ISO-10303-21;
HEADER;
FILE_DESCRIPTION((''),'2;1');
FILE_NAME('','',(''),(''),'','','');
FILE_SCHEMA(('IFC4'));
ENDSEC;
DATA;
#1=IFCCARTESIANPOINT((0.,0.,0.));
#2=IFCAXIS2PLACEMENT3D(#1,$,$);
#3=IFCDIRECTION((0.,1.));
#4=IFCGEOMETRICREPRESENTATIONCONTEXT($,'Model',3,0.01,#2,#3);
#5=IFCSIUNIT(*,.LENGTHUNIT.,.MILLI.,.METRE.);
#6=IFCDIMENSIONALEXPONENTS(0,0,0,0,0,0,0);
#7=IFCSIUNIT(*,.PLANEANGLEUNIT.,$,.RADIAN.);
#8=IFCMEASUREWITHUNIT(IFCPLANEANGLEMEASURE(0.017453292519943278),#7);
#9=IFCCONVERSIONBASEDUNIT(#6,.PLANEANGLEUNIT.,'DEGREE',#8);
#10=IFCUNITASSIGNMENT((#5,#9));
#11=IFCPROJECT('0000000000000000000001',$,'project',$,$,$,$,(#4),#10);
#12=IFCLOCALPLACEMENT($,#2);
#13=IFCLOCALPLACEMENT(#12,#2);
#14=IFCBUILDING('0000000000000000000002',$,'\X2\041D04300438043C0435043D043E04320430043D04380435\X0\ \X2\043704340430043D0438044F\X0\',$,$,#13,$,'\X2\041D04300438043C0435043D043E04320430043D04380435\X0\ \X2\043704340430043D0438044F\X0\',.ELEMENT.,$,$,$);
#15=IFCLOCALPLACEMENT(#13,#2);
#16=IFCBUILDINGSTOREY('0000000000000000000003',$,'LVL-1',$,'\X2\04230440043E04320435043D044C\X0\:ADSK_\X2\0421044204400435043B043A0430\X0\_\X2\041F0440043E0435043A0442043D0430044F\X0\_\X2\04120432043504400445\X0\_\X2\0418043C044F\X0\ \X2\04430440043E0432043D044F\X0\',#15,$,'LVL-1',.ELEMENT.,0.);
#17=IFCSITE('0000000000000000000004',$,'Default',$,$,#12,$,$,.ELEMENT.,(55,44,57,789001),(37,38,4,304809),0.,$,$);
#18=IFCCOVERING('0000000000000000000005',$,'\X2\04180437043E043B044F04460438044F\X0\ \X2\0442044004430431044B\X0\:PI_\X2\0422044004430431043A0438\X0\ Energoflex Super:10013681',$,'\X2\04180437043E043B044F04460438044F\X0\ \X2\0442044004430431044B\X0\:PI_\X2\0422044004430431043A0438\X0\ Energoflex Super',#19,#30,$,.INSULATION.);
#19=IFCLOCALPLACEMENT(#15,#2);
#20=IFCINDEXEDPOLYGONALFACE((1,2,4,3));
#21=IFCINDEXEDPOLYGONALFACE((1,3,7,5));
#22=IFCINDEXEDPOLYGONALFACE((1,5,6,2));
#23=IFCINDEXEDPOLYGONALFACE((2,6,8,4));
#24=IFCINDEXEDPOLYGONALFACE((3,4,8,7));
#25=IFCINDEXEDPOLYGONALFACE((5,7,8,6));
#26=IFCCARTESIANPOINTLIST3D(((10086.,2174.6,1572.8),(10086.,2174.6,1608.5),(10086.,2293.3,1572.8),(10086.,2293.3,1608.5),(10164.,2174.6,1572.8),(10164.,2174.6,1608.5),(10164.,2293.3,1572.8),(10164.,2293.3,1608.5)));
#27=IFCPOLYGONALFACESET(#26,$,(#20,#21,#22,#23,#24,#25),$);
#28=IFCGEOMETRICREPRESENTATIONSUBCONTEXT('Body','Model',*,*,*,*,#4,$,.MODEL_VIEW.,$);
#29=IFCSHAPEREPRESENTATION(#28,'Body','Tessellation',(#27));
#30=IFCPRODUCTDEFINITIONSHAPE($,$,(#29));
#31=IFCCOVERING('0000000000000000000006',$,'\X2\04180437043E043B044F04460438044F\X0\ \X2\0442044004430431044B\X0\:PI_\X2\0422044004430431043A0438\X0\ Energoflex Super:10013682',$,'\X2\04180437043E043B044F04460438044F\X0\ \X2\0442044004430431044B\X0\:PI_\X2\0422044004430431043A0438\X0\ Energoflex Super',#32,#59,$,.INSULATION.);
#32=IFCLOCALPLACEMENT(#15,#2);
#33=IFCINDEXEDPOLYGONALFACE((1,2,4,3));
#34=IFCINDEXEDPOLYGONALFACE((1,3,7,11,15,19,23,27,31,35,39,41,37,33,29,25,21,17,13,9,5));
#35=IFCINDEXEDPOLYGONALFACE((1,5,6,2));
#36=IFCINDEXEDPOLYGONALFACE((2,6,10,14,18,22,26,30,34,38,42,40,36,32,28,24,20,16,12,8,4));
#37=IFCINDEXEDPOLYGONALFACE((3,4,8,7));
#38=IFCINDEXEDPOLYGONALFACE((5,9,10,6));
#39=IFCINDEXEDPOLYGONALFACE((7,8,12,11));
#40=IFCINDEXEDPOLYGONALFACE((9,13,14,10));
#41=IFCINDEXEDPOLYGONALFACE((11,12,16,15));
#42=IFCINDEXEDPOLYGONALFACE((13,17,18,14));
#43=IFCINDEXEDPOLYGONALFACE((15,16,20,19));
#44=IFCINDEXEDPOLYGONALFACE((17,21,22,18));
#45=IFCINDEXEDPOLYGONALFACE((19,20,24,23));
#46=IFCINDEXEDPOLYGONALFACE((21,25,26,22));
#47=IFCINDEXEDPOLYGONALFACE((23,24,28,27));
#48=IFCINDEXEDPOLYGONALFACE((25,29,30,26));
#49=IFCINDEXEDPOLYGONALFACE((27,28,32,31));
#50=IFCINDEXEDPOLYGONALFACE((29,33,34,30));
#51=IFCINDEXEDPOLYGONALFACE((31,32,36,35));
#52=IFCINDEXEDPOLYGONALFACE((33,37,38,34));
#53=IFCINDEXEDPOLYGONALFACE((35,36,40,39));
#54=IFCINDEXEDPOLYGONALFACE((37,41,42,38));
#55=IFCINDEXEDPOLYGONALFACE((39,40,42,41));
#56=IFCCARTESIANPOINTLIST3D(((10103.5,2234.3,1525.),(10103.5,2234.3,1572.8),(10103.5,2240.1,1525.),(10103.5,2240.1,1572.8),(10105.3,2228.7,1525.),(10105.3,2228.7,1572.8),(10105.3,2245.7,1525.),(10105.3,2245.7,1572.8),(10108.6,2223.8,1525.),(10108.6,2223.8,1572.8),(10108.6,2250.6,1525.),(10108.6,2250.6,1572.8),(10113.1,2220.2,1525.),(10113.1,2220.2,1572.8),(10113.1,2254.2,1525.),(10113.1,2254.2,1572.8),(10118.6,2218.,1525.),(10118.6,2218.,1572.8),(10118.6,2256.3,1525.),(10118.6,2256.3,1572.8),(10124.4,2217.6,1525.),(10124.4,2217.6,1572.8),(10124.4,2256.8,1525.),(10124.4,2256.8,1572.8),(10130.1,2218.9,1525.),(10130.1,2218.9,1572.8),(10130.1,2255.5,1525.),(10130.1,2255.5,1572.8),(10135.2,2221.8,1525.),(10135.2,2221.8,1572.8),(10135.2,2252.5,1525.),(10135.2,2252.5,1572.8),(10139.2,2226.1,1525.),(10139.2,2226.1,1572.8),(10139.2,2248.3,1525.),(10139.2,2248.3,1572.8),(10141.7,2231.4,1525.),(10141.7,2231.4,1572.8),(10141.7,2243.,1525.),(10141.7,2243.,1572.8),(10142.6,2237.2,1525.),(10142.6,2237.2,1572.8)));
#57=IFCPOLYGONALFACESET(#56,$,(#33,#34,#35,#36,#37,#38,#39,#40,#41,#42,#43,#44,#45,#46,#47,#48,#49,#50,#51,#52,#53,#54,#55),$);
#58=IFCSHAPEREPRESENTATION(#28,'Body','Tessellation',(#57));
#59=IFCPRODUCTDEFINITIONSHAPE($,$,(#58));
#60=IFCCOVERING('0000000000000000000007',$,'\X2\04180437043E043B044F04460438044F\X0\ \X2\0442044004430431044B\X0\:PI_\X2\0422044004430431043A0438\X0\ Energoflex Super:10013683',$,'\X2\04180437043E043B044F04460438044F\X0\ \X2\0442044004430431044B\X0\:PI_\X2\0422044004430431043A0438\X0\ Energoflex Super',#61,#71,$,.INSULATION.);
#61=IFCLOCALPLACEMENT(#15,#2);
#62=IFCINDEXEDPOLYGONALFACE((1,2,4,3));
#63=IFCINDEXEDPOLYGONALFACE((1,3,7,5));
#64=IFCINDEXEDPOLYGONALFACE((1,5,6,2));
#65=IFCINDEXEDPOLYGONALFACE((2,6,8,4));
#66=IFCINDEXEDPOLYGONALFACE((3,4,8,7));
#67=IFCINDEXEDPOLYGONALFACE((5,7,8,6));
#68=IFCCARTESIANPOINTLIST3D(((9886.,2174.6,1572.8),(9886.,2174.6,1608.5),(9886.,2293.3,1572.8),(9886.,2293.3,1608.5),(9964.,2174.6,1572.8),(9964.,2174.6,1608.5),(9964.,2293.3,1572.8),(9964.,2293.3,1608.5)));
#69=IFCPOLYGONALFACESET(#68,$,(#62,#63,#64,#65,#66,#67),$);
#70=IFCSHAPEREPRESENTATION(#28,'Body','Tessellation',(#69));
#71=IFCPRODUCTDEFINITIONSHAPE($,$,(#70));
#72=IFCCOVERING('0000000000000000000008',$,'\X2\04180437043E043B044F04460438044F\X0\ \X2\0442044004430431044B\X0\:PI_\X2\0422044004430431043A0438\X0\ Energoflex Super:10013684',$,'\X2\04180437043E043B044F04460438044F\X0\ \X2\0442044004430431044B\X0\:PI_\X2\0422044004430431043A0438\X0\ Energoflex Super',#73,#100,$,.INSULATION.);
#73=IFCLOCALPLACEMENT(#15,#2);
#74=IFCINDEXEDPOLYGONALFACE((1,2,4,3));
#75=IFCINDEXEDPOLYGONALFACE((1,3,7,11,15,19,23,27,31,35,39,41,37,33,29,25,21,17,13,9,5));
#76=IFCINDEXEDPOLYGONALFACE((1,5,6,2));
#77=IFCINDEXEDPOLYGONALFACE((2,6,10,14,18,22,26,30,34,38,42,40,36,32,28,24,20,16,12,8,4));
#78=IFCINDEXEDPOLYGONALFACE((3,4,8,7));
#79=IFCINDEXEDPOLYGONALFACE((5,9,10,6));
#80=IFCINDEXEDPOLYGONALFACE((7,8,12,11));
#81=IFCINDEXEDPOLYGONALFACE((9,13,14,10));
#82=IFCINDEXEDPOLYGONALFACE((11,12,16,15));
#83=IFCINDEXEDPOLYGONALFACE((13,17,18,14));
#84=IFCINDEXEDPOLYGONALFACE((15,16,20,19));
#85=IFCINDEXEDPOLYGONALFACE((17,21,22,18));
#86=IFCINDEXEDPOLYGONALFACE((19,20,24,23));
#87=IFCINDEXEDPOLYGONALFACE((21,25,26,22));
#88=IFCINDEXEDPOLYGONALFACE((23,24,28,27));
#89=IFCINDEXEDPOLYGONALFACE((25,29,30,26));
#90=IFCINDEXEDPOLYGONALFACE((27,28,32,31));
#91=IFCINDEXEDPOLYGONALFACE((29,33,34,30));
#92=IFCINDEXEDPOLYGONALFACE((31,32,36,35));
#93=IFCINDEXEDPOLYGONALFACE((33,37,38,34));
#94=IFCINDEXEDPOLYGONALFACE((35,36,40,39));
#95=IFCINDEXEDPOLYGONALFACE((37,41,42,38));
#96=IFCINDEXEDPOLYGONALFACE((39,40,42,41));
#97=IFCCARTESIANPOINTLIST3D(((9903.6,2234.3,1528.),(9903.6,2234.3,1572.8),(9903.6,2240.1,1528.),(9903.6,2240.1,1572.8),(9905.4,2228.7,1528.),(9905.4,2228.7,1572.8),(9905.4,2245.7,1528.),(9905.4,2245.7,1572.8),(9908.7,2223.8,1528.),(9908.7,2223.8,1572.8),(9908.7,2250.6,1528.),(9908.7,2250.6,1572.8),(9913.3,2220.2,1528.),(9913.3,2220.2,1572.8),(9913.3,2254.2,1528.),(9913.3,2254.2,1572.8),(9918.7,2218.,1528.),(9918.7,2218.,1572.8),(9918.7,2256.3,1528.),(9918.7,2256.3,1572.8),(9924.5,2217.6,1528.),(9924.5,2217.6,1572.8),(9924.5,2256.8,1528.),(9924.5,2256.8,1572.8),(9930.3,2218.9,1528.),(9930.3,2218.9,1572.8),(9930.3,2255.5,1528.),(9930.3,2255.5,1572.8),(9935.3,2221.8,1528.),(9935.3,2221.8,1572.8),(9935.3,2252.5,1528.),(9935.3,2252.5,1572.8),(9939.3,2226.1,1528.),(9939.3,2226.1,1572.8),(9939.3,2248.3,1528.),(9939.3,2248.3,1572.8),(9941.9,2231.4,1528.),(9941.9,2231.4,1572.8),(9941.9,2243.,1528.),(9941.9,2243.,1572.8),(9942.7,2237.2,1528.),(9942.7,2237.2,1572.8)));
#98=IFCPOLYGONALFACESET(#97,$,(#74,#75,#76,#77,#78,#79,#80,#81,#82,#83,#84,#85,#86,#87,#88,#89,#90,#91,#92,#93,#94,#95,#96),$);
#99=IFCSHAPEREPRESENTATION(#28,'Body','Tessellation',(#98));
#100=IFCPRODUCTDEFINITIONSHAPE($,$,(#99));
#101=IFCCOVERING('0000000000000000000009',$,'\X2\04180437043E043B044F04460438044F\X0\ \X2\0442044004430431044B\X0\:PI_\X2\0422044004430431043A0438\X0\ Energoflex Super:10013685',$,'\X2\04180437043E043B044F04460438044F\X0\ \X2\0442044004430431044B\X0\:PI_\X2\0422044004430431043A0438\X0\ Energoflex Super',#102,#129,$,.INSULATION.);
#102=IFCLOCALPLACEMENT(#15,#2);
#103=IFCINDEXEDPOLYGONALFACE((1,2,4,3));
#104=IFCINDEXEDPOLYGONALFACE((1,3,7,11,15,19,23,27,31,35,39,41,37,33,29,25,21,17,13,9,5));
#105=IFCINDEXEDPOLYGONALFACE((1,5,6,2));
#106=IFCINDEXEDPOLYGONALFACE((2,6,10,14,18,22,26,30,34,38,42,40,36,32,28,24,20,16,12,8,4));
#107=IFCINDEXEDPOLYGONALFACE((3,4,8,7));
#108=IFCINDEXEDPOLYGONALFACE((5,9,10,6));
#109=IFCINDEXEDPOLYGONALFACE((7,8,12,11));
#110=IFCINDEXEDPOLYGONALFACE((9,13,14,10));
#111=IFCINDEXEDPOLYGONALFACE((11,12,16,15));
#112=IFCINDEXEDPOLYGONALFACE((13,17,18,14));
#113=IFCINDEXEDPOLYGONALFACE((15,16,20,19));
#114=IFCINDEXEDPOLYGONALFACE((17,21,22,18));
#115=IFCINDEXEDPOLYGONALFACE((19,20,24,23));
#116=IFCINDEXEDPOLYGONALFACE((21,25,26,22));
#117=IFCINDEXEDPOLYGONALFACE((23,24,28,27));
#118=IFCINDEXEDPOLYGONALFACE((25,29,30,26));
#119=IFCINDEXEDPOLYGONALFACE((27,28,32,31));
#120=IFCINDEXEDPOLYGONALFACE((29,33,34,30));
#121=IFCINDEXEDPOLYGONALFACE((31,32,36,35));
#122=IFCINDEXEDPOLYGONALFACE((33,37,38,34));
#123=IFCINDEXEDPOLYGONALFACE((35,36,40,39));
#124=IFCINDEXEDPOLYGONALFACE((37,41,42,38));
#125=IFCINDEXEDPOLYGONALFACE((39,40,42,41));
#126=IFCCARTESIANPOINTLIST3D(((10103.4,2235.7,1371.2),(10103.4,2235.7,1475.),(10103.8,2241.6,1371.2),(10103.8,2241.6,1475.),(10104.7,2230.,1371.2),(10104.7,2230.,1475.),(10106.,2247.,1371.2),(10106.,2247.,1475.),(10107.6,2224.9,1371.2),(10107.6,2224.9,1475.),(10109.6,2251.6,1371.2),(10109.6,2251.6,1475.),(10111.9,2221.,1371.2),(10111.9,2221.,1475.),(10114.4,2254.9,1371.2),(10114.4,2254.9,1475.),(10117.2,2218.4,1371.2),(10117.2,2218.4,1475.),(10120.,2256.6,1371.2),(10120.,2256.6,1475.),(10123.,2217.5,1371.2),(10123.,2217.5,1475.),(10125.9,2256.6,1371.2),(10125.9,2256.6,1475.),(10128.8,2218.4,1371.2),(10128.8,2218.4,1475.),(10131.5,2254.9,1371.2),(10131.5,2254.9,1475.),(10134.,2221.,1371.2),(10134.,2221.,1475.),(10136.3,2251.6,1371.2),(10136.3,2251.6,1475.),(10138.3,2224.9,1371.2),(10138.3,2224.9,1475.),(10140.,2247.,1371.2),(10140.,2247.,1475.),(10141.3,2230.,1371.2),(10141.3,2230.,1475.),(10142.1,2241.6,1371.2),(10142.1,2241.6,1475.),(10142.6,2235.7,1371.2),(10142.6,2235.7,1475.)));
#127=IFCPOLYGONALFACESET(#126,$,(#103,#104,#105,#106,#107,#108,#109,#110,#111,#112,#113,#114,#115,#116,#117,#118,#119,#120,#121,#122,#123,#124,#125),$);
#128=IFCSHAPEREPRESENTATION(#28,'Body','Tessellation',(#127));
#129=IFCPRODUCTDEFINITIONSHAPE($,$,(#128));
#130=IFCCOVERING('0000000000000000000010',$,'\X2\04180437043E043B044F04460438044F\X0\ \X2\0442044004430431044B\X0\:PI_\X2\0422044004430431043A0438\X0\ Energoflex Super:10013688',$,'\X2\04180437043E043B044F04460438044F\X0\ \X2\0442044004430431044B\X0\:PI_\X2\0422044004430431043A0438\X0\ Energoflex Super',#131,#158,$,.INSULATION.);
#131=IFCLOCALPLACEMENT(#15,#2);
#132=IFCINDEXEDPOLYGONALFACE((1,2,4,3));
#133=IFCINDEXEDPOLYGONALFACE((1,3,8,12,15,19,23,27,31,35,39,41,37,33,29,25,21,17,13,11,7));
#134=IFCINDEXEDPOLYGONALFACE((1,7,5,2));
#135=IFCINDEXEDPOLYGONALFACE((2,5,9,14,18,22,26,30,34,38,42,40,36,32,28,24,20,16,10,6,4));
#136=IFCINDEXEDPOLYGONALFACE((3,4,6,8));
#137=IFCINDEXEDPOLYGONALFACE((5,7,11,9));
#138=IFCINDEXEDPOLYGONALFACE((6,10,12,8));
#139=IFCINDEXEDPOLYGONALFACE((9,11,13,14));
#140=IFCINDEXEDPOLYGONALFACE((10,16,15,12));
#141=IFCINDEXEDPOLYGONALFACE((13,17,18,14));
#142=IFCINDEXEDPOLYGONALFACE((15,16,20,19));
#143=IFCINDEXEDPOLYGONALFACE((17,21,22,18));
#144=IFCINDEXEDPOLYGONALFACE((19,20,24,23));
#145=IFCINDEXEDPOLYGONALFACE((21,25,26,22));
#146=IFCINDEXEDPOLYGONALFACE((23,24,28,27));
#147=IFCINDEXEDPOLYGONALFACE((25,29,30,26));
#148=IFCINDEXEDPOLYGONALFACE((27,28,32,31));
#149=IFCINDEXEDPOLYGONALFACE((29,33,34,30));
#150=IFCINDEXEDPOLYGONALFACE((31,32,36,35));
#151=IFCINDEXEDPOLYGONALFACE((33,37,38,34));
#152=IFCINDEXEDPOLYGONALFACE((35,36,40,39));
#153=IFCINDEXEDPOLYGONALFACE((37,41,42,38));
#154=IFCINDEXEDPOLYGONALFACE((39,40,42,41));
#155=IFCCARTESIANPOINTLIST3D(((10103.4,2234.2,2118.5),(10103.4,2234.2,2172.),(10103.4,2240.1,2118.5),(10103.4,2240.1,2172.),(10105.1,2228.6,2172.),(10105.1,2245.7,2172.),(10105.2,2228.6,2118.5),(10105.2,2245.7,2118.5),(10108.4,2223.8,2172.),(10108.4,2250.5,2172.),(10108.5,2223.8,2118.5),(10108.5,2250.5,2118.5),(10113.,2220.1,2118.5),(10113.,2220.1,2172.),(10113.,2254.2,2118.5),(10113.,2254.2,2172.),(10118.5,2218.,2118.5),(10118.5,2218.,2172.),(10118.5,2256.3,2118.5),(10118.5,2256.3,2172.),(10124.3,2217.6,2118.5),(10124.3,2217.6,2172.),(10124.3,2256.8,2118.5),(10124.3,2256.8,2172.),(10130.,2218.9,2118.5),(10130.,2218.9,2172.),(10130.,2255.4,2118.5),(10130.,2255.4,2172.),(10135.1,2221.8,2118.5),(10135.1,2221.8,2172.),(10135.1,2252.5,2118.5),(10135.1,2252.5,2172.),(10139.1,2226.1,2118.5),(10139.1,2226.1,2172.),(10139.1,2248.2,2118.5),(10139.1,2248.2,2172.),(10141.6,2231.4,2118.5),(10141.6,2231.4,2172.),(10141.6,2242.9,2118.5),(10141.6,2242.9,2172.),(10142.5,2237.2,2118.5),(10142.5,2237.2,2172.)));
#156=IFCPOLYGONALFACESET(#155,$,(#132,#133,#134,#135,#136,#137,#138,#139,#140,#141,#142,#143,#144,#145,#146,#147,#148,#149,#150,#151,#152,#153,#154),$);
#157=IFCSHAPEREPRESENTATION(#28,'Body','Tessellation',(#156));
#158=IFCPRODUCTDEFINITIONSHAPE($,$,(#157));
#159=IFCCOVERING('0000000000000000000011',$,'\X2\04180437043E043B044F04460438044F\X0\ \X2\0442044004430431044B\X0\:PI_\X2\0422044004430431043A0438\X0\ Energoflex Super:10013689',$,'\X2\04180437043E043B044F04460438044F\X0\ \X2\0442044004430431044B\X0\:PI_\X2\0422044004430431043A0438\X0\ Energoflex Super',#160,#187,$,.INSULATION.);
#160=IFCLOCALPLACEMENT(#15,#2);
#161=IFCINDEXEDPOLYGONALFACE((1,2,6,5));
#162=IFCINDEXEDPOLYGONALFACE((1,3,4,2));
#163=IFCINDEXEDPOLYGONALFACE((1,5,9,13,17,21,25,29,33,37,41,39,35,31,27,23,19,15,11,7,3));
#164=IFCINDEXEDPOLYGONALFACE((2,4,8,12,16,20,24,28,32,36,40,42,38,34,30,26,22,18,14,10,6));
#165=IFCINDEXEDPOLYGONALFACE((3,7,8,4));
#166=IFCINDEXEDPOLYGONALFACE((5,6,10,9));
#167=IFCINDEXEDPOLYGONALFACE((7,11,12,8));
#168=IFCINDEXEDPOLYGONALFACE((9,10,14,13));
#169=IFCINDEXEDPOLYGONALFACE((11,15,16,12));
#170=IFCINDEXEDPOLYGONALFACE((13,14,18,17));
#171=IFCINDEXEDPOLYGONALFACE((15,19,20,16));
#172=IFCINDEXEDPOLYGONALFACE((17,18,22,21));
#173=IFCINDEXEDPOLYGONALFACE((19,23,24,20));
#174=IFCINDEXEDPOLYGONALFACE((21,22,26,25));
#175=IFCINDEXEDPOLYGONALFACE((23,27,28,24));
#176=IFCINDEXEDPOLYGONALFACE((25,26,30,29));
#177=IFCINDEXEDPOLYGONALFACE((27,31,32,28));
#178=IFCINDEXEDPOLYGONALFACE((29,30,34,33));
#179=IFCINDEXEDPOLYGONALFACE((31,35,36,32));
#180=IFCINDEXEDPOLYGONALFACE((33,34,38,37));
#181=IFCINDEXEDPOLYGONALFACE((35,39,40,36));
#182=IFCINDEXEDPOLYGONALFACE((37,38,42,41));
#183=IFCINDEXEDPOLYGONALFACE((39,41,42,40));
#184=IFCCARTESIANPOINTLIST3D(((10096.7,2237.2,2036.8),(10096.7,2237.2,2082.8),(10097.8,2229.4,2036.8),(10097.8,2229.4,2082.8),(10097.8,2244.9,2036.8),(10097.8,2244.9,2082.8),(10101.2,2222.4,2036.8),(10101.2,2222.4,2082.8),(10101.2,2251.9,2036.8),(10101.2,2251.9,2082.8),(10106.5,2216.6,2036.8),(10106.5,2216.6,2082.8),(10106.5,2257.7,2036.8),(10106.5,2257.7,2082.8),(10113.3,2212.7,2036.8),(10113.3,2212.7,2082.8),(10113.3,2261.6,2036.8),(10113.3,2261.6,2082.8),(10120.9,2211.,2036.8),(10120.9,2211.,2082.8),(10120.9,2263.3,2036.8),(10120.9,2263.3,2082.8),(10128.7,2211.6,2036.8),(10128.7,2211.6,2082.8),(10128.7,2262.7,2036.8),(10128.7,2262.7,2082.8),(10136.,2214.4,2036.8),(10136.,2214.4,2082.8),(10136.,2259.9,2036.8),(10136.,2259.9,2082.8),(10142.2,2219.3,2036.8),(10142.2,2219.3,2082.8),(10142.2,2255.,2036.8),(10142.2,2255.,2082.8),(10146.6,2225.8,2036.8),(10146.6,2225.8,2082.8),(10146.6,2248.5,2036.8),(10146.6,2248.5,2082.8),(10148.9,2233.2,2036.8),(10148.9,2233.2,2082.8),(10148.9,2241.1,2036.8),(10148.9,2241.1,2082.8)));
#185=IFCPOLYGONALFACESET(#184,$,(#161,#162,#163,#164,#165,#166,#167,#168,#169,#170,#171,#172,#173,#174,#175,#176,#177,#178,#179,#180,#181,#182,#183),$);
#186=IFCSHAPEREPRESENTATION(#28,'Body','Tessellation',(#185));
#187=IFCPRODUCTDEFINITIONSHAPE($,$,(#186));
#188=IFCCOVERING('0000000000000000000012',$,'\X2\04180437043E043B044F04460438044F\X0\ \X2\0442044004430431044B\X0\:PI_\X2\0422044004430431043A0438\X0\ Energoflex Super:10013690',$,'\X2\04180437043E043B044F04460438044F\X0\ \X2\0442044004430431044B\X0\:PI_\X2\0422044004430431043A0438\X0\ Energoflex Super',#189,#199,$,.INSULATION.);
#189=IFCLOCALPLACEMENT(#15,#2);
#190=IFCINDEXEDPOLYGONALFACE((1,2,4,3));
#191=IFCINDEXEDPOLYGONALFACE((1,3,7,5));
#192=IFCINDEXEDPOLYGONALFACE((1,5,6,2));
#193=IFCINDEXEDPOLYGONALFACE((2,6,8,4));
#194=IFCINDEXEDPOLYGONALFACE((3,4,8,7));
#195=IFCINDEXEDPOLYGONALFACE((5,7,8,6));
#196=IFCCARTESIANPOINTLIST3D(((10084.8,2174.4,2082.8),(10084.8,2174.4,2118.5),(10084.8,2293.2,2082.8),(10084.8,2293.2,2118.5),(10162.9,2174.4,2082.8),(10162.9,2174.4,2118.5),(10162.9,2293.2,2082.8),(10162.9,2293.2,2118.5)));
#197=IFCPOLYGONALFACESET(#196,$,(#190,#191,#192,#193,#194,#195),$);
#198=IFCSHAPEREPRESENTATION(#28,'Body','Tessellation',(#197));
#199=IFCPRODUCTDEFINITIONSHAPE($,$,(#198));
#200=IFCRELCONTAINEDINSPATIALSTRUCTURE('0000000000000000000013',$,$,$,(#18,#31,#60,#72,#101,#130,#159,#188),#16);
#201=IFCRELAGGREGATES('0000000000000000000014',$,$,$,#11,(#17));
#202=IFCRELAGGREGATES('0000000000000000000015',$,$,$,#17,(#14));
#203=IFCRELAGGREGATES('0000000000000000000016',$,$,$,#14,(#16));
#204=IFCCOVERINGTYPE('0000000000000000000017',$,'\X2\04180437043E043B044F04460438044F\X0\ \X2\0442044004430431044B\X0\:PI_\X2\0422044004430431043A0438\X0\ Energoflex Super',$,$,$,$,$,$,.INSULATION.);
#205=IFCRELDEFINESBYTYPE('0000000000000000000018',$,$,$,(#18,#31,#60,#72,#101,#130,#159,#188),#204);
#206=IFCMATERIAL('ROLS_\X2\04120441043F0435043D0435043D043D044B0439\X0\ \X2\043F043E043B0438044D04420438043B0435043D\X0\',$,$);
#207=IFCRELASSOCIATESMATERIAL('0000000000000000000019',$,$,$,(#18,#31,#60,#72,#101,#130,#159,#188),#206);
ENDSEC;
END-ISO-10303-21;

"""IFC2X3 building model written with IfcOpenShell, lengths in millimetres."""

from ifc_helpers import new_model, entity, si_unit, converted_unit, direction, frame, frame_2d, origin, origin_2d_with_axis, place, context, subcontext, project, spatial, rectangle, circle, extrude, material, type_object, element, save


model = new_model("IFC2X3")

# Units and contexts
model_context = context("Model", 3, precision=0.01, world=origin(), true_north=direction((0.0, 1.0)))
body_context = subcontext(model_context, "Body", "Model", "MODEL_VIEW")
ifc_project = project(units=[si_unit("LENGTHUNIT", "METRE", prefix="MILLI"), converted_unit("PLANEANGLEUNIT", "DEGREE", entity("IfcPlaneAngleMeasure", 0.017453292519943278), si_unit("PLANEANGLEUNIT", "RADIAN"), dimensions=[0, 0, 0, 0, 0, 0, 0])], contexts=[model_context])

# Site, building, storey
site_placement = place(None, origin())
site = spatial("IfcSite", under=ifc_project, at=site_placement, Name="Default", CompositionType="ELEMENT", RefLatitude=(55, 44, 57, 789001), RefLongitude=(37, 38, 4, 304809), RefElevation=0.0)
building_placement = place(site_placement, origin())
building = spatial("IfcBuilding", under=site, at=building_placement, Name="Наименование здания", LongName="Наименование здания", CompositionType="ELEMENT")
storey_placement = place(building_placement, origin())
storey = spatial("IfcBuildingStorey", under=building, at=storey_placement, Name="LVL-1", ObjectType="Уровень:ADSK_Стрелка_Проектная_Вверх_Имя уровня", LongName="LVL-1", CompositionType="ELEMENT", Elevation=0.0)

# Coverings
ifc_material = material(Name="ROLS_Вспененный полиэтилен")
covering_type = type_object("IfcCoveringType", Name="Изоляция трубы:PI_Трубки Energoflex Super", PredefinedType="INSULATION")
covering_1_placement = place(storey_placement, origin())
element("IfcCovering", 1, at=covering_1_placement, inside=storey, type_object=covering_type, material=ifc_material, Name="Изоляция трубы:PI_Трубки Energoflex Super:10013681", ObjectType="Изоляция трубы:PI_Трубки Energoflex Super", PredefinedType="INSULATION", context=body_context, shape_type="SweptSolid", body=[
    extrude(rectangle(XDim=78.0, YDim=118.7, at=frame_2d((0.0, 0.0), x_axis=(1.0, 0.0))), frame((10125.0, 2233.9, 1572.8)), (0.0, 0.0, 1.0), 35.7),
])
covering_2_placement = place(storey_placement, origin())
element("IfcCovering", 2, at=covering_2_placement, inside=storey, type_object=covering_type, material=ifc_material, Name="Изоляция трубы:PI_Трубки Energoflex Super:10013682", ObjectType="Изоляция трубы:PI_Трубки Energoflex Super", PredefinedType="INSULATION", context=body_context, shape_type="SweptSolid", body=[
    extrude(circle(Radius=19.6, at=origin_2d_with_axis()), frame((10123.0, 2237.2, 1525.0)), (0.0, 0.0, 1.0), 47.8),
])
covering_3_placement = place(storey_placement, origin())
element("IfcCovering", 3, at=covering_3_placement, inside=storey, type_object=covering_type, material=ifc_material, Name="Изоляция трубы:PI_Трубки Energoflex Super:10013683", ObjectType="Изоляция трубы:PI_Трубки Energoflex Super", PredefinedType="INSULATION", context=body_context, shape_type="SweptSolid", body=[
    extrude(rectangle(XDim=78.0, YDim=118.7, at=frame_2d((0.0, 0.0), x_axis=(1.0, 0.0))), frame((9925.0, 2233.9, 1572.8)), (0.0, 0.0, 1.0), 35.7),
])
covering_4_placement = place(storey_placement, origin())
element("IfcCovering", 4, at=covering_4_placement, inside=storey, type_object=covering_type, material=ifc_material, Name="Изоляция трубы:PI_Трубки Energoflex Super:10013684", ObjectType="Изоляция трубы:PI_Трубки Energoflex Super", PredefinedType="INSULATION", context=body_context, shape_type="SweptSolid", body=[
    extrude(circle(Radius=19.6, at=origin_2d_with_axis()), frame((9923.1, 2237.2, 1528.0)), (0.0, 0.0, 1.0), 44.8),
])
covering_5_placement = place(storey_placement, origin())
element("IfcCovering", 5, at=covering_5_placement, inside=storey, type_object=covering_type, material=ifc_material, Name="Изоляция трубы:PI_Трубки Energoflex Super:10013685", ObjectType="Изоляция трубы:PI_Трубки Energoflex Super", PredefinedType="INSULATION", context=body_context, shape_type="SweptSolid", body=[
    extrude(circle(Radius=19.6, at=frame_2d((0.0, 0.0), x_axis=(1.0, 0.0))), frame((10123.0, 2237.2, 1371.2), z_axis=(0.0, 0.0, 1.0), x_axis=(0.0, -1.0, 0.0)), (0.0, 0.0, 1.0), 103.8),
])
covering_6_placement = place(storey_placement, origin())
element("IfcCovering", 6, at=covering_6_placement, inside=storey, type_object=covering_type, material=ifc_material, Name="Изоляция трубы:PI_Трубки Energoflex Super:10013688", ObjectType="Изоляция трубы:PI_Трубки Energoflex Super", PredefinedType="INSULATION", context=body_context, shape_type="SweptSolid", body=[
    extrude(circle(Radius=19.6, at=origin_2d_with_axis()), frame((10122.9, 2237.2, 2118.5), z_axis=(-0.000466, 0.0, 1.0), x_axis=(1.0, 0.0, 0.000466)), (0.0, 0.0, 1.0), 53.5),
])
covering_7_placement = place(storey_placement, origin())
element("IfcCovering", 7, at=covering_7_placement, inside=storey, type_object=covering_type, material=ifc_material, Name="Изоляция трубы:PI_Трубки Energoflex Super:10013689", ObjectType="Изоляция трубы:PI_Трубки Energoflex Super", PredefinedType="INSULATION", context=body_context, shape_type="SweptSolid", body=[
    extrude(circle(Radius=26.2, at=origin_2d_with_axis()), frame((10122.9, 2237.2, 2036.8), z_axis=(0.0, 0.0, 1.0), x_axis=(-1.0, 0.0, 0.0)), (0.0, 0.0, 1.0), 46.0),
])
covering_8_placement = place(storey_placement, origin())
element("IfcCovering", 8, at=covering_8_placement, inside=storey, type_object=covering_type, material=ifc_material, Name="Изоляция трубы:PI_Трубки Energoflex Super:10013690", ObjectType="Изоляция трубы:PI_Трубки Energoflex Super", PredefinedType="INSULATION", context=body_context, shape_type="SweptSolid", body=[
    extrude(rectangle(XDim=78.1, YDim=118.7, at=frame_2d((0.0, 0.0), x_axis=(1.0, 0.0))), frame((10123.9, 2233.8, 2082.8), z_axis=(-0.000466, 0.0, 1.0), x_axis=(1.0, 0.0, 0.000466)), (0.000466, 0.0, 1.0), 35.7),
])

save(model, "model.ifc")
